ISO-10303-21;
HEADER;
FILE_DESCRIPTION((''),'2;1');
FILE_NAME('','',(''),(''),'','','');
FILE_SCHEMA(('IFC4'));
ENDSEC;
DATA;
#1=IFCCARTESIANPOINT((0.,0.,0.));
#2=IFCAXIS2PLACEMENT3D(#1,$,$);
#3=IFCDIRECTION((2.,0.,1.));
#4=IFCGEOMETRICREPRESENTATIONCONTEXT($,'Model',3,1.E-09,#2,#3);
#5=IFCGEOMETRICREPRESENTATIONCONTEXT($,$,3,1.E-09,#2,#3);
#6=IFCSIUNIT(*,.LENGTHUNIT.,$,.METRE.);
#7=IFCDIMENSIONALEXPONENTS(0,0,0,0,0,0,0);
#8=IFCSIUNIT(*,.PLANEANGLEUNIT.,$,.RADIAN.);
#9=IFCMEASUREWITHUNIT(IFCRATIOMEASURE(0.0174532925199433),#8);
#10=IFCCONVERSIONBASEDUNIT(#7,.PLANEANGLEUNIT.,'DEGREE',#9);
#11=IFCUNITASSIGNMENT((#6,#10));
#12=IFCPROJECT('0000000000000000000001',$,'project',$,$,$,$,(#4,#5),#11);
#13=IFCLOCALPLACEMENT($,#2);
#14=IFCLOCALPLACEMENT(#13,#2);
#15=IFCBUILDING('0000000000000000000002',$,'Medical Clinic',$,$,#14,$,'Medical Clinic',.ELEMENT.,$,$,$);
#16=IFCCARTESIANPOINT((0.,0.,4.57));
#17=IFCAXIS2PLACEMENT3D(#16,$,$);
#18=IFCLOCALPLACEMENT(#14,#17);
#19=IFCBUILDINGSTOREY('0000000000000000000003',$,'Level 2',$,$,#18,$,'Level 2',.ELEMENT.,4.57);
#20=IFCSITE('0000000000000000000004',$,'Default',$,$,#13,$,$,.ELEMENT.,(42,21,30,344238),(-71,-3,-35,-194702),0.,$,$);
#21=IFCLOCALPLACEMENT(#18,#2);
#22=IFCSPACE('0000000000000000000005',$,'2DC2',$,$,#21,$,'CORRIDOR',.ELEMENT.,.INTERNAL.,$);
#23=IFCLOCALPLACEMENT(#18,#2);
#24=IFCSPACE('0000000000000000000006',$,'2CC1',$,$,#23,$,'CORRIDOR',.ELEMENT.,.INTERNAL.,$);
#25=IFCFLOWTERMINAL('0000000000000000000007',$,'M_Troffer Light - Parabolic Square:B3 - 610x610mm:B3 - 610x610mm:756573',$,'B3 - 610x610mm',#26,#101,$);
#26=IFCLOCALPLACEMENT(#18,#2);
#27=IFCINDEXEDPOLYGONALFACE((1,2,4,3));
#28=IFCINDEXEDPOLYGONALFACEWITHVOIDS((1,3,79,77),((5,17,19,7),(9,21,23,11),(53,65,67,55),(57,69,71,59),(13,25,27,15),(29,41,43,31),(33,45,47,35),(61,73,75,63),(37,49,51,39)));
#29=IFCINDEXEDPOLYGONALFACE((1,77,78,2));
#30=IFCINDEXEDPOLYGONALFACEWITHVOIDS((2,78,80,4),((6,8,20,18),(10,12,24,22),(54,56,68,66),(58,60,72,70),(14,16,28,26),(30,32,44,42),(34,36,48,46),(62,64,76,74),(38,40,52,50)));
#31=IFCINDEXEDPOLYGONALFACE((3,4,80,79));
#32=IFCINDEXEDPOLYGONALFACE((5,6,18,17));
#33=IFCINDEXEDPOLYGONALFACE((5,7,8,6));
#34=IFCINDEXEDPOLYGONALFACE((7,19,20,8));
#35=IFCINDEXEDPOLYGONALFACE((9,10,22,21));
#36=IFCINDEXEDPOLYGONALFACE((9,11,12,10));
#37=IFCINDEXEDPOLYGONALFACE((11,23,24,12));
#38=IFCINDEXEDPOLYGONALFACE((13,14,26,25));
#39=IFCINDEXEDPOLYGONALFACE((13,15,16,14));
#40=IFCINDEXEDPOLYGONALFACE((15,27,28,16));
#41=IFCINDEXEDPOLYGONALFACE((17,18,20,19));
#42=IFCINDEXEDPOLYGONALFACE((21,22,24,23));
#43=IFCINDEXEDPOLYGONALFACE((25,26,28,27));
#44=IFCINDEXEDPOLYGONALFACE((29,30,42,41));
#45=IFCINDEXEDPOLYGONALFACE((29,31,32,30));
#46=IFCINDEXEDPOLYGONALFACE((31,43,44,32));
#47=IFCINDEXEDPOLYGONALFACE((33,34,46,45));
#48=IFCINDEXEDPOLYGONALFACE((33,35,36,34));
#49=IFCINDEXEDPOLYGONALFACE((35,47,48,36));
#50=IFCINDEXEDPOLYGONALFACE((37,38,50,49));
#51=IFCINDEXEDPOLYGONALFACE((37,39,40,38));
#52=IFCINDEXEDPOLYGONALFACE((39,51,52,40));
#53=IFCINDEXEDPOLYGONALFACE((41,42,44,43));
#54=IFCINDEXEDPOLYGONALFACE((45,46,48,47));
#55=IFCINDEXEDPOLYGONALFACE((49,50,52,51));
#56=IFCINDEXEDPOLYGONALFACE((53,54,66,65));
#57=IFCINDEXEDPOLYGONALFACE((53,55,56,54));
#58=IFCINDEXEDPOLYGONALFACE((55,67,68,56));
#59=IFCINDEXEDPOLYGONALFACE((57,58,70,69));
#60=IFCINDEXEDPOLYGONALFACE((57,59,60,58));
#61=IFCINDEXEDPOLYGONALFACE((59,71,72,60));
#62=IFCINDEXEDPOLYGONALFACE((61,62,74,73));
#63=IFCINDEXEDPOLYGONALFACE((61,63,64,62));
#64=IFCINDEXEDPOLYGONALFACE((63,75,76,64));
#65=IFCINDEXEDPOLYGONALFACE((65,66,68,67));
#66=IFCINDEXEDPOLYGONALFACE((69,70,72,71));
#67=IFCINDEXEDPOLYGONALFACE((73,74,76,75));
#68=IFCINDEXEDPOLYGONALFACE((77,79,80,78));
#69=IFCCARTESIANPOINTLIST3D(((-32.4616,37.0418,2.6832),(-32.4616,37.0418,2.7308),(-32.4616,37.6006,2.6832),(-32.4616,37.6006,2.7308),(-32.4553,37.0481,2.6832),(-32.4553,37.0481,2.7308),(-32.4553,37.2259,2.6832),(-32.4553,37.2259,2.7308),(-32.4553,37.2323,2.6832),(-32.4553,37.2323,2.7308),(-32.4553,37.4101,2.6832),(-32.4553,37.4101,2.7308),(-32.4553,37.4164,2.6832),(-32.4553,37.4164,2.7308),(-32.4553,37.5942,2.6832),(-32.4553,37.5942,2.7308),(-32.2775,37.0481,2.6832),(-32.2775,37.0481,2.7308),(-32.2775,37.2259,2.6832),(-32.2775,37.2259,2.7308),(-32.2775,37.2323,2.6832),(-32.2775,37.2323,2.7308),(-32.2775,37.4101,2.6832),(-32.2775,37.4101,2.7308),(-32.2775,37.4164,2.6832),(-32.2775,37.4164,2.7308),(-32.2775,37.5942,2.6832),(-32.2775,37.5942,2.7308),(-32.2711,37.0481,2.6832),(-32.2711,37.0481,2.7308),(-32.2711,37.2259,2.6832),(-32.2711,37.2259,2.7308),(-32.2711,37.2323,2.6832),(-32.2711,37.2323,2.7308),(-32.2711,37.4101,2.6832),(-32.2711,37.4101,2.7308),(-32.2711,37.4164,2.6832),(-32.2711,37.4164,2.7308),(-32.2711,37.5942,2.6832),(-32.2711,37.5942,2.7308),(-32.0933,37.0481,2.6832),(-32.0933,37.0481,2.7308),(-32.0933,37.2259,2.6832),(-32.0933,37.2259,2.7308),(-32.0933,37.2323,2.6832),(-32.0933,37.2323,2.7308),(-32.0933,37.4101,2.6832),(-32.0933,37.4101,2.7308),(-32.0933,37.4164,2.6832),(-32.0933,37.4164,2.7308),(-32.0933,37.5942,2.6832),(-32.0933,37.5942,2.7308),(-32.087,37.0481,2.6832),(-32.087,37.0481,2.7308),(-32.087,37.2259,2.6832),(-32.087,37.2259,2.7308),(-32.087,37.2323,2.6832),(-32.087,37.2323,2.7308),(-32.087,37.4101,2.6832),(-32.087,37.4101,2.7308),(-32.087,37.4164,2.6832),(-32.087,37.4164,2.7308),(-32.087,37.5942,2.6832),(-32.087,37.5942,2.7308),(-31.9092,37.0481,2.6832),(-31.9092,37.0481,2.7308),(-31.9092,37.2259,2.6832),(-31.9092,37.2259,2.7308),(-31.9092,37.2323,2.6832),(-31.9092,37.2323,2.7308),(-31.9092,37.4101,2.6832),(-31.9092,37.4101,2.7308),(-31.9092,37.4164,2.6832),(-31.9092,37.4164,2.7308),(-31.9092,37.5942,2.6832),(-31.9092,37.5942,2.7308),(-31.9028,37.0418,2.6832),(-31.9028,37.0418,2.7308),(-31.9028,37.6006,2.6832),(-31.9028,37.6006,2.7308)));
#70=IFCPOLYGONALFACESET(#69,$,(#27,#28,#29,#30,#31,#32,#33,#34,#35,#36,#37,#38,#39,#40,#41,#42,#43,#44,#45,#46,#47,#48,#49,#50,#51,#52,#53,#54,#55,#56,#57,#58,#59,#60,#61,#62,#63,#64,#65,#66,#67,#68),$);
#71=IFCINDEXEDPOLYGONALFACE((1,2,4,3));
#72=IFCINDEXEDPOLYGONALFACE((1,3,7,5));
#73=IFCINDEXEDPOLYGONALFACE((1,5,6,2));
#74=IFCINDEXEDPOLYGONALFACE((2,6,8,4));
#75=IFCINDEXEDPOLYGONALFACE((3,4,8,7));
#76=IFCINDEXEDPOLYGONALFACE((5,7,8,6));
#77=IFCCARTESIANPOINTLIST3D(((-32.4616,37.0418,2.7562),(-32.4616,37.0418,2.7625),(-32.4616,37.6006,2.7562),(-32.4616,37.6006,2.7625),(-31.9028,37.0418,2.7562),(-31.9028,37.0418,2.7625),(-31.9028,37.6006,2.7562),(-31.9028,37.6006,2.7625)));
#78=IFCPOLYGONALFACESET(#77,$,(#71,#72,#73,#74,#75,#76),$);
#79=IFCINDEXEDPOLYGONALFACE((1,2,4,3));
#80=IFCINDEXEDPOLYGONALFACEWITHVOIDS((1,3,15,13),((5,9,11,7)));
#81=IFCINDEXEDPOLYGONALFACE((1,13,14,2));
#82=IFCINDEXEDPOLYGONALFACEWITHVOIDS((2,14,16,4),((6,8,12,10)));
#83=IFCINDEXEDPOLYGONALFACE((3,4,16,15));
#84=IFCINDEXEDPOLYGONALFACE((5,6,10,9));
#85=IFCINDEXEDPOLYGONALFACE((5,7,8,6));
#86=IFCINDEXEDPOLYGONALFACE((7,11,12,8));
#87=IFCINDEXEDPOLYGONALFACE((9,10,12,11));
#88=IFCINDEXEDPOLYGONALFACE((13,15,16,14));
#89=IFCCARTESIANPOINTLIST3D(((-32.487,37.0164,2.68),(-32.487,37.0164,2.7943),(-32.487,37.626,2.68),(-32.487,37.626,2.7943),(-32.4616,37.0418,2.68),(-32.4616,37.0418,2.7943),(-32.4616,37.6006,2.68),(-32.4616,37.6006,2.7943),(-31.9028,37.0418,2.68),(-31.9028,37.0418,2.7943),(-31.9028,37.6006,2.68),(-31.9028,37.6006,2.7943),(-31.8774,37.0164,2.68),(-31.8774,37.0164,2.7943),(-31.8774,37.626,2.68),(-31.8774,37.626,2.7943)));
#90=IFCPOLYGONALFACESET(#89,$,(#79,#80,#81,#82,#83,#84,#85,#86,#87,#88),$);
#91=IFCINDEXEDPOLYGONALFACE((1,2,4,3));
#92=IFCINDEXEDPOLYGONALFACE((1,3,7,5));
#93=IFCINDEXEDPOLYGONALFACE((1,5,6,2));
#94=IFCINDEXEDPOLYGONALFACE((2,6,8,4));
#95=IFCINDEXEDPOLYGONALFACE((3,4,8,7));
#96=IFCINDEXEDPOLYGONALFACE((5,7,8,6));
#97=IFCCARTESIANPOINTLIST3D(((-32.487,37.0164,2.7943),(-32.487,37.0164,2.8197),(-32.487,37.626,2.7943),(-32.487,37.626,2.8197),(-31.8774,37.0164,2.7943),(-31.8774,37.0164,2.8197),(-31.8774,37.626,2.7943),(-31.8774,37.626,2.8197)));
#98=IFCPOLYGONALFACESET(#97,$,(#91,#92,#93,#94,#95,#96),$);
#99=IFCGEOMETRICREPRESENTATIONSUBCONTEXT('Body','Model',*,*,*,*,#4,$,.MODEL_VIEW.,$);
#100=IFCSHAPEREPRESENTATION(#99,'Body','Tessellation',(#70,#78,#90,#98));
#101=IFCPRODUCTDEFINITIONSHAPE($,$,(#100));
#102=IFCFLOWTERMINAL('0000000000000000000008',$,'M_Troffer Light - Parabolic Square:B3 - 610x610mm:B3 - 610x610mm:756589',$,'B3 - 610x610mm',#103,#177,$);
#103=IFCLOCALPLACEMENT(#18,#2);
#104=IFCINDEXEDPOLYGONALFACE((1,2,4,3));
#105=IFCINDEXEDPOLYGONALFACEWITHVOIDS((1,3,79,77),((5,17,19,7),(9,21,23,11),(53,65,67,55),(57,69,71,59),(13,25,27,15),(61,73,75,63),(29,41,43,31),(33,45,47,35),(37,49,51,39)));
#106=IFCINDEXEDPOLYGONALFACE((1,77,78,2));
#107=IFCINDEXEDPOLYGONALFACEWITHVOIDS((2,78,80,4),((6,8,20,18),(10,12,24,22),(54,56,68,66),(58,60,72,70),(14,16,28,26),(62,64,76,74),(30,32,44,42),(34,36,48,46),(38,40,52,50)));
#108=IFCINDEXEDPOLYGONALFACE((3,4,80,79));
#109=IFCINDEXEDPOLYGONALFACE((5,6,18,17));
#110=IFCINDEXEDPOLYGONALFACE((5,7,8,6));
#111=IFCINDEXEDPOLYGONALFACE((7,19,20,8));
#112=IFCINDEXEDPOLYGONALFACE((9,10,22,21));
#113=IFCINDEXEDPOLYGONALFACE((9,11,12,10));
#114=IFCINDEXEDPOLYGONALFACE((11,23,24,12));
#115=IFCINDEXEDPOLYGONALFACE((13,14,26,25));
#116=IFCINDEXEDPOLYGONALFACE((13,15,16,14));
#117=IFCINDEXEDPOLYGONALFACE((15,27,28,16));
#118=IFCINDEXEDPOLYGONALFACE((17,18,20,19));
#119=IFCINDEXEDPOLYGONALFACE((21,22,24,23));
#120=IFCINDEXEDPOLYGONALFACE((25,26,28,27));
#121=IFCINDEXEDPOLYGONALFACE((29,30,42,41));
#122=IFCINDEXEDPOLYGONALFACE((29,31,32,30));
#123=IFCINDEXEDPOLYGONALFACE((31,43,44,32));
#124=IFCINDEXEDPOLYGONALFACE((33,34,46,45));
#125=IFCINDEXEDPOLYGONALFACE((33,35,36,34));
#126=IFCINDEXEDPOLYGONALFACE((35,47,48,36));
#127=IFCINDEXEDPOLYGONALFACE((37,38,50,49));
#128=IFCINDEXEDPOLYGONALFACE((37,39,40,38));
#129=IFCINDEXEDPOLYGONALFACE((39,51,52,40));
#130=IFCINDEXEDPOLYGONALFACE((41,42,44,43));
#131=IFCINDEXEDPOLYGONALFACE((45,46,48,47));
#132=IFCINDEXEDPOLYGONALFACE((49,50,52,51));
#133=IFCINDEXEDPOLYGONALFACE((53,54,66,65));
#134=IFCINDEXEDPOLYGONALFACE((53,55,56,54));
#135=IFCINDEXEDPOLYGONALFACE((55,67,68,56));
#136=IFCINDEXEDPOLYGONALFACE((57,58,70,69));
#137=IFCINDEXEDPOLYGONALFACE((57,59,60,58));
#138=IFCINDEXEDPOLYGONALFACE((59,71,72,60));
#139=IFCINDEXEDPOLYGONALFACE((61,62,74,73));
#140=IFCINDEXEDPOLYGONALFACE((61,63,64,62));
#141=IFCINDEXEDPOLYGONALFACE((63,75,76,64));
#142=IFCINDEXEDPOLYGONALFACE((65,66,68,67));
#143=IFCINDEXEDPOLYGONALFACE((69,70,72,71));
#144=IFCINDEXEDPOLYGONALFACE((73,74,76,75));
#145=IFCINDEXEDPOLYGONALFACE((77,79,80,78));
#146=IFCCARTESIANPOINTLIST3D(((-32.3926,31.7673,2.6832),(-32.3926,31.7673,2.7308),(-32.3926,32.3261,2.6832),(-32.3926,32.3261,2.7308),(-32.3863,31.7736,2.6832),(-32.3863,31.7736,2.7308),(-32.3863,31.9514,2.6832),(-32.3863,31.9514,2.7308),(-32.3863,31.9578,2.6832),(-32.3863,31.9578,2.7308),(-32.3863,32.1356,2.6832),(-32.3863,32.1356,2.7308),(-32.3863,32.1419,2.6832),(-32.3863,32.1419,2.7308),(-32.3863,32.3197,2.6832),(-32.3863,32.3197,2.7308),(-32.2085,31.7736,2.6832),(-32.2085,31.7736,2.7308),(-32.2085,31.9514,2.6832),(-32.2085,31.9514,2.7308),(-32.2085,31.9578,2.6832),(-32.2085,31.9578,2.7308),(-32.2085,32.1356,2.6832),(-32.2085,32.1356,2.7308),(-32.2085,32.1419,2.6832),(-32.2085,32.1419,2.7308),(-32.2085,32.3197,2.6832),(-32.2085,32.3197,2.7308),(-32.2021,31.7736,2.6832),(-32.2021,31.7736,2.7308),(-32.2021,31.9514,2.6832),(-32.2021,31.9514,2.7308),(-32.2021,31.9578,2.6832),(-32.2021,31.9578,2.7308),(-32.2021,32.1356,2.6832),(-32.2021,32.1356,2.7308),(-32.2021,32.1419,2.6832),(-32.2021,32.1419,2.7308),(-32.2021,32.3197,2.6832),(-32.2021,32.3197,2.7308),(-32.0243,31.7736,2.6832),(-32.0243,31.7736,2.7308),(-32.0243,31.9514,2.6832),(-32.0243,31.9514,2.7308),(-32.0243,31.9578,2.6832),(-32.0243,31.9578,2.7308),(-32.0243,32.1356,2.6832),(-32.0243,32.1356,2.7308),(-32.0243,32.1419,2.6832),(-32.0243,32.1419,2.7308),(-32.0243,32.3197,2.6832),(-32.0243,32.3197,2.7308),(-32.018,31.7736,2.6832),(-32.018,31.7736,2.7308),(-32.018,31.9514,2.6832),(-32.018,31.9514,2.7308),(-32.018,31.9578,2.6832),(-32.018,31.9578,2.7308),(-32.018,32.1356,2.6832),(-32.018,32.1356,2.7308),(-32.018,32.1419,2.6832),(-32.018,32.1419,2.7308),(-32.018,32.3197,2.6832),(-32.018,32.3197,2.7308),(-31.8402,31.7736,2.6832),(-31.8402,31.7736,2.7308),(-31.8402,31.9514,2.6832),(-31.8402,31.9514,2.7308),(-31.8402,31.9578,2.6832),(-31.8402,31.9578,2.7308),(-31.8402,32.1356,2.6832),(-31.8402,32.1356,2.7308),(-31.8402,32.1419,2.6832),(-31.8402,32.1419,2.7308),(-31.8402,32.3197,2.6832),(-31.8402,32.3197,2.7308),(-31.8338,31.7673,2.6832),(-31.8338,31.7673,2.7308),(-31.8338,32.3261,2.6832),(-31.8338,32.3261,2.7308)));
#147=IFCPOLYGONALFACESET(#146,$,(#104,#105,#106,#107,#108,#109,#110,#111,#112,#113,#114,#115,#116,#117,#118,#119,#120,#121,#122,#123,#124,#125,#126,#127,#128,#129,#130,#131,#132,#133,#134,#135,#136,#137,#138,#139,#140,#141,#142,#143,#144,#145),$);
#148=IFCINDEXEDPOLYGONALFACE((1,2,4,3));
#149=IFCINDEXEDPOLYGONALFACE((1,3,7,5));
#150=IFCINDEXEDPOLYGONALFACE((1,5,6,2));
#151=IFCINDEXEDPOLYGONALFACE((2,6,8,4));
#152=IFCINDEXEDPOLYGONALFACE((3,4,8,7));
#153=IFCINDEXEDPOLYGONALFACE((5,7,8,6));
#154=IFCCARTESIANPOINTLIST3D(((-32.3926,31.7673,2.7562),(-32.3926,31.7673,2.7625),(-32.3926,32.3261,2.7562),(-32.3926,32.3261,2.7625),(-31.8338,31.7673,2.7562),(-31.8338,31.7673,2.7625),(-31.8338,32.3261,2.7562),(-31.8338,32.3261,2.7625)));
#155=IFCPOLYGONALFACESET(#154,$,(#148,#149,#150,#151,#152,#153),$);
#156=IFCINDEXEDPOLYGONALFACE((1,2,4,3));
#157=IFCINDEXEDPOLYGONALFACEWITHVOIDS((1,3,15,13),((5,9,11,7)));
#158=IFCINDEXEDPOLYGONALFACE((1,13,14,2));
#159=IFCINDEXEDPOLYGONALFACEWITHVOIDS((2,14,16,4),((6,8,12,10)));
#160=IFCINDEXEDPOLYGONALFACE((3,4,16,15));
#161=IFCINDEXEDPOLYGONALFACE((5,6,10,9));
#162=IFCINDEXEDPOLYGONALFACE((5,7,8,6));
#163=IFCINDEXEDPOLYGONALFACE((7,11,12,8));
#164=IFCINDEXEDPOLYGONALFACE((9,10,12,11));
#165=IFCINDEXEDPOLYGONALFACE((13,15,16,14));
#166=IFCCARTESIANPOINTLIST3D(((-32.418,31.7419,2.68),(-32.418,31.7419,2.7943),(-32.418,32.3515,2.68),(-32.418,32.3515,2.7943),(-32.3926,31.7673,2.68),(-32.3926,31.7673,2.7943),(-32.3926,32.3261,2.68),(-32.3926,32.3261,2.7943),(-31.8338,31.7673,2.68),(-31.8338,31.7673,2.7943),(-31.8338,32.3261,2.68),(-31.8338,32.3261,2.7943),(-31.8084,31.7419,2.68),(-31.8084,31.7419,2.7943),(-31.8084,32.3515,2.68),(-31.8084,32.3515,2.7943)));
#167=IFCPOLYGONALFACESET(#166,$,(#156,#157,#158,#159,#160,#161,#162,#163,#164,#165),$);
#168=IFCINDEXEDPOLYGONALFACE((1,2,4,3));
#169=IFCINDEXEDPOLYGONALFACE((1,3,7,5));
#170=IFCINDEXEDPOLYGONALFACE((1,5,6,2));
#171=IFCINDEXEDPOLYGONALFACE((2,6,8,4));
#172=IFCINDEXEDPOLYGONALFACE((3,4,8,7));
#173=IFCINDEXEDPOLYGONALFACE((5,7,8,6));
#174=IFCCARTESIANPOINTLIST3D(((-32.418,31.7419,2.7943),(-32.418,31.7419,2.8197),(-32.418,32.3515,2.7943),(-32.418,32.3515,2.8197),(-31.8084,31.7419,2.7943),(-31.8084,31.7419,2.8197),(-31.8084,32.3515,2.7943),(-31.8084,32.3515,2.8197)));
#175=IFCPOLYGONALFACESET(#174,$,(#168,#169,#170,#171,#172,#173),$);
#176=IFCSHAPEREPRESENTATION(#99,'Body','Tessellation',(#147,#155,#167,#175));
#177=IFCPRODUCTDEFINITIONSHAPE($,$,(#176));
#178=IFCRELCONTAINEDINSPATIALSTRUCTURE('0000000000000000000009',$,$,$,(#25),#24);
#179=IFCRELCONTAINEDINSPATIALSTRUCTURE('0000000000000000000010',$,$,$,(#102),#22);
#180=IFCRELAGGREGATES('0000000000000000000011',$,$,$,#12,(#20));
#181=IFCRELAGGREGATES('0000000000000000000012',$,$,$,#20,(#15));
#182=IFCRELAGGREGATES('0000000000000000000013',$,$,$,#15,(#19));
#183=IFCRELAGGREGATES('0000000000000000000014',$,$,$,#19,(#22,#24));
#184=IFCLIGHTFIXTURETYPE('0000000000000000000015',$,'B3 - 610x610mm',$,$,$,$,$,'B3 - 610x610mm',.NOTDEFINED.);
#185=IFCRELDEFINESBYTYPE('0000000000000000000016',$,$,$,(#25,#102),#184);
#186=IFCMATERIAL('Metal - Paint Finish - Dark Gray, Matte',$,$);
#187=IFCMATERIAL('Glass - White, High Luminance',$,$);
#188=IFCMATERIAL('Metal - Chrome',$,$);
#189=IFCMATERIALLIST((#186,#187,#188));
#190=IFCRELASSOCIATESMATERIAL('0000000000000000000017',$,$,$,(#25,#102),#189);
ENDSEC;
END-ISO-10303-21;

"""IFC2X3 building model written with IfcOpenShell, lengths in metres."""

from ifc_helpers import new_model, entity, si_unit, converted_unit, direction, frame, origin, origin_2d_with_axis, place, context, subcontext, project, spatial, polyline, rectangle, outline, extrude, source, transform, mapped, material, material_list, type_object, type_shapes, element, save


model = new_model("IFC2X3")

# Units and contexts
model_context = context("Model", 3, precision=1e-09, world=origin(), true_north=direction((2.0, 0.0, 1.0)))
context_of_model = context(None, 3, precision=1e-09, world=origin(), true_north=direction((2.0, 0.0, 1.0)))
body_context = subcontext(model_context, "Body", "Model", "MODEL_VIEW")
ifc_project = project(units=[si_unit("LENGTHUNIT", "METRE"), converted_unit("PLANEANGLEUNIT", "DEGREE", entity("IfcRatioMeasure", 0.0174532925199433), si_unit("PLANEANGLEUNIT", "RADIAN"), dimensions=[0, 0, 0, 0, 0, 0, 0])], contexts=[model_context, context_of_model])

# Site, building, storey, space
site_placement = place(None, origin())
site = spatial("IfcSite", under=ifc_project, at=site_placement, Name="Default", CompositionType="ELEMENT", RefLatitude=(42, 21, 30, 344238), RefLongitude=(-71, -3, -35, -194702), RefElevation=0.0)
building_placement = place(site_placement, origin())
building = spatial("IfcBuilding", under=site, at=building_placement, Name="Medical Clinic", LongName="Medical Clinic", CompositionType="ELEMENT")
storey_placement = place(building_placement, frame((0.0, 0.0, 4.57)))
storey = spatial("IfcBuildingStorey", under=building, at=storey_placement, Name="Level 2", LongName="Level 2", CompositionType="ELEMENT", Elevation=4.57)
space_1_placement = place(storey_placement, origin())
space_1 = spatial("IfcSpace", under=storey, at=space_1_placement, Name="2DC2", LongName="CORRIDOR", CompositionType="ELEMENT", InteriorOrExteriorSpace="INTERNAL")

# Shared definitions
space_2_placement = place(storey_placement, origin())
space_2 = spatial("IfcSpace", under=storey, at=space_2_placement, Name="2CC1", LongName="CORRIDOR", CompositionType="ELEMENT", InteriorOrExteriorSpace="INTERNAL")

# Flow terminals
ifc_material_1 = material(Name="Metal - Paint Finish - Dark Gray, Matte")
ifc_material_2 = material(Name="Glass - White, High Luminance")
ifc_material_3 = material(Name="Metal - Chrome")
ifc_material_list_1 = material_list([ifc_material_1, ifc_material_2, ifc_material_3])
light_fixture_type_1 = type_object("IfcLightFixtureType", Name="B3 - 610x610mm", ElementType="B3 - 610x610mm", PredefinedType="NOTDEFINED")
shared_shape_1 = source(origin(), body_context, "Body", "SweptSolid", [
    extrude(outline(polyline([(-0.2794, -0.2794), (0.2794, -0.2794), (0.2794, 0.2794), (-0.2794, 0.2794), (-0.2794, -0.2794)]), holes=[polyline([(-0.0952, 0.0953), (-0.273, 0.0953), (-0.273, 0.2731), (-0.0952, 0.2731), (-0.0952, 0.0953)]), polyline([(0.2731, 0.0953), (0.0953, 0.0953), (0.0953, 0.2731), (0.2731, 0.2731), (0.2731, 0.0953)]), polyline([(-0.0889, 0.2731), (0.0889, 0.2731), (0.0889, 0.0953), (-0.0889, 0.0953), (-0.0889, 0.2731)]), polyline([(0.2731, -0.273), (0.0953, -0.273), (0.0953, -0.0952), (0.2731, -0.0952), (0.2731, -0.273)]), polyline([(0.0889, -0.273), (-0.0889, -0.273), (-0.0889, -0.0952), (0.0889, -0.0952), (0.0889, -0.273)]), polyline([(-0.0952, -0.273), (-0.273, -0.273), (-0.273, -0.0952), (-0.0952, -0.0952), (-0.0952, -0.273)]), polyline([(-0.0952, -0.0889), (-0.273, -0.0889), (-0.273, 0.0889), (-0.0952, 0.0889), (-0.0952, -0.0889)]), polyline([(0.0889, -0.0889), (-0.0889, -0.0889), (-0.0889, 0.0889), (0.0889, 0.0889), (0.0889, -0.0889)]), polyline([(0.2731, -0.0889), (0.0953, -0.0889), (0.0953, 0.0889), (0.2731, 0.0889), (0.2731, -0.0889)])]), frame((0.0, -0.3048, -0.0508), z_axis=(0.0, 0.0, 1.0), x_axis=(-1.0, 0.0, 0.0)), (0.0, 0.0, 1.0), 0.0476),
    extrude(rectangle(XDim=0.5588, YDim=0.5588, at=origin_2d_with_axis()), frame((0.0, -0.3048, -0.0825), z_axis=(0.0, 0.0, 1.0), x_axis=(-1.0, 0.0, 0.0)), (0.0, 0.0, 1.0), 0.0064),
    extrude(outline(polyline([(-0.3048, -0.3048), (0.3048, -0.3048), (0.3048, 0.3048), (-0.3048, 0.3048), (-0.3048, -0.3048)]), holes=[polyline([(0.2794, 0.2794), (0.2794, -0.2794), (-0.2794, -0.2794), (-0.2794, 0.2794), (0.2794, 0.2794)])]), frame((0.0, -0.3048, -0.1143)), (0.0, 0.0, 1.0), 0.1143),
    extrude(rectangle(XDim=0.6096, YDim=0.6096, at=origin_2d_with_axis()), frame((0.0, -0.3048, -0.1397), z_axis=(0.0, 0.0, 1.0), x_axis=(-1.0, 0.0, 0.0)), (0.0, 0.0, 1.0), 0.0254),
])
type_shapes(light_fixture_type_1, [shared_shape_1])
flow_terminal_1_placement = place(space_2_placement, frame((-32.1822, 37.0164, 2.68), z_axis=(0.0, 0.0, -1.0), x_axis=(1.0, 0.0, 0.0)))
element("IfcFlowTerminal", 1, at=flow_terminal_1_placement, inside=space_2, type_object=light_fixture_type_1, material=ifc_material_list_1, Name="M_Troffer Light - Parabolic Square:B3 - 610x610mm:B3 - 610x610mm:756573", ObjectType="B3 - 610x610mm", context=body_context, shape_type="MappedRepresentation", body=[
    mapped(shared_shape_1, transform((0.0, 0.0, 0.0), scale=1.0)),
])
flow_terminal_2_placement = place(space_1_placement, frame((-32.1132, 31.7419, 2.68), z_axis=(0.0, 0.0, -1.0), x_axis=(1.0, 0.0, 0.0)))
element("IfcFlowTerminal", 2, at=flow_terminal_2_placement, inside=space_1, type_object=light_fixture_type_1, material=ifc_material_list_1, Name="M_Troffer Light - Parabolic Square:B3 - 610x610mm:B3 - 610x610mm:756589", ObjectType="B3 - 610x610mm", context=body_context, shape_type="MappedRepresentation", body=[
    mapped(shared_shape_1, transform((0.0, 0.0, 0.0), scale=1.0)),
])

save(model, "model.ifc")
